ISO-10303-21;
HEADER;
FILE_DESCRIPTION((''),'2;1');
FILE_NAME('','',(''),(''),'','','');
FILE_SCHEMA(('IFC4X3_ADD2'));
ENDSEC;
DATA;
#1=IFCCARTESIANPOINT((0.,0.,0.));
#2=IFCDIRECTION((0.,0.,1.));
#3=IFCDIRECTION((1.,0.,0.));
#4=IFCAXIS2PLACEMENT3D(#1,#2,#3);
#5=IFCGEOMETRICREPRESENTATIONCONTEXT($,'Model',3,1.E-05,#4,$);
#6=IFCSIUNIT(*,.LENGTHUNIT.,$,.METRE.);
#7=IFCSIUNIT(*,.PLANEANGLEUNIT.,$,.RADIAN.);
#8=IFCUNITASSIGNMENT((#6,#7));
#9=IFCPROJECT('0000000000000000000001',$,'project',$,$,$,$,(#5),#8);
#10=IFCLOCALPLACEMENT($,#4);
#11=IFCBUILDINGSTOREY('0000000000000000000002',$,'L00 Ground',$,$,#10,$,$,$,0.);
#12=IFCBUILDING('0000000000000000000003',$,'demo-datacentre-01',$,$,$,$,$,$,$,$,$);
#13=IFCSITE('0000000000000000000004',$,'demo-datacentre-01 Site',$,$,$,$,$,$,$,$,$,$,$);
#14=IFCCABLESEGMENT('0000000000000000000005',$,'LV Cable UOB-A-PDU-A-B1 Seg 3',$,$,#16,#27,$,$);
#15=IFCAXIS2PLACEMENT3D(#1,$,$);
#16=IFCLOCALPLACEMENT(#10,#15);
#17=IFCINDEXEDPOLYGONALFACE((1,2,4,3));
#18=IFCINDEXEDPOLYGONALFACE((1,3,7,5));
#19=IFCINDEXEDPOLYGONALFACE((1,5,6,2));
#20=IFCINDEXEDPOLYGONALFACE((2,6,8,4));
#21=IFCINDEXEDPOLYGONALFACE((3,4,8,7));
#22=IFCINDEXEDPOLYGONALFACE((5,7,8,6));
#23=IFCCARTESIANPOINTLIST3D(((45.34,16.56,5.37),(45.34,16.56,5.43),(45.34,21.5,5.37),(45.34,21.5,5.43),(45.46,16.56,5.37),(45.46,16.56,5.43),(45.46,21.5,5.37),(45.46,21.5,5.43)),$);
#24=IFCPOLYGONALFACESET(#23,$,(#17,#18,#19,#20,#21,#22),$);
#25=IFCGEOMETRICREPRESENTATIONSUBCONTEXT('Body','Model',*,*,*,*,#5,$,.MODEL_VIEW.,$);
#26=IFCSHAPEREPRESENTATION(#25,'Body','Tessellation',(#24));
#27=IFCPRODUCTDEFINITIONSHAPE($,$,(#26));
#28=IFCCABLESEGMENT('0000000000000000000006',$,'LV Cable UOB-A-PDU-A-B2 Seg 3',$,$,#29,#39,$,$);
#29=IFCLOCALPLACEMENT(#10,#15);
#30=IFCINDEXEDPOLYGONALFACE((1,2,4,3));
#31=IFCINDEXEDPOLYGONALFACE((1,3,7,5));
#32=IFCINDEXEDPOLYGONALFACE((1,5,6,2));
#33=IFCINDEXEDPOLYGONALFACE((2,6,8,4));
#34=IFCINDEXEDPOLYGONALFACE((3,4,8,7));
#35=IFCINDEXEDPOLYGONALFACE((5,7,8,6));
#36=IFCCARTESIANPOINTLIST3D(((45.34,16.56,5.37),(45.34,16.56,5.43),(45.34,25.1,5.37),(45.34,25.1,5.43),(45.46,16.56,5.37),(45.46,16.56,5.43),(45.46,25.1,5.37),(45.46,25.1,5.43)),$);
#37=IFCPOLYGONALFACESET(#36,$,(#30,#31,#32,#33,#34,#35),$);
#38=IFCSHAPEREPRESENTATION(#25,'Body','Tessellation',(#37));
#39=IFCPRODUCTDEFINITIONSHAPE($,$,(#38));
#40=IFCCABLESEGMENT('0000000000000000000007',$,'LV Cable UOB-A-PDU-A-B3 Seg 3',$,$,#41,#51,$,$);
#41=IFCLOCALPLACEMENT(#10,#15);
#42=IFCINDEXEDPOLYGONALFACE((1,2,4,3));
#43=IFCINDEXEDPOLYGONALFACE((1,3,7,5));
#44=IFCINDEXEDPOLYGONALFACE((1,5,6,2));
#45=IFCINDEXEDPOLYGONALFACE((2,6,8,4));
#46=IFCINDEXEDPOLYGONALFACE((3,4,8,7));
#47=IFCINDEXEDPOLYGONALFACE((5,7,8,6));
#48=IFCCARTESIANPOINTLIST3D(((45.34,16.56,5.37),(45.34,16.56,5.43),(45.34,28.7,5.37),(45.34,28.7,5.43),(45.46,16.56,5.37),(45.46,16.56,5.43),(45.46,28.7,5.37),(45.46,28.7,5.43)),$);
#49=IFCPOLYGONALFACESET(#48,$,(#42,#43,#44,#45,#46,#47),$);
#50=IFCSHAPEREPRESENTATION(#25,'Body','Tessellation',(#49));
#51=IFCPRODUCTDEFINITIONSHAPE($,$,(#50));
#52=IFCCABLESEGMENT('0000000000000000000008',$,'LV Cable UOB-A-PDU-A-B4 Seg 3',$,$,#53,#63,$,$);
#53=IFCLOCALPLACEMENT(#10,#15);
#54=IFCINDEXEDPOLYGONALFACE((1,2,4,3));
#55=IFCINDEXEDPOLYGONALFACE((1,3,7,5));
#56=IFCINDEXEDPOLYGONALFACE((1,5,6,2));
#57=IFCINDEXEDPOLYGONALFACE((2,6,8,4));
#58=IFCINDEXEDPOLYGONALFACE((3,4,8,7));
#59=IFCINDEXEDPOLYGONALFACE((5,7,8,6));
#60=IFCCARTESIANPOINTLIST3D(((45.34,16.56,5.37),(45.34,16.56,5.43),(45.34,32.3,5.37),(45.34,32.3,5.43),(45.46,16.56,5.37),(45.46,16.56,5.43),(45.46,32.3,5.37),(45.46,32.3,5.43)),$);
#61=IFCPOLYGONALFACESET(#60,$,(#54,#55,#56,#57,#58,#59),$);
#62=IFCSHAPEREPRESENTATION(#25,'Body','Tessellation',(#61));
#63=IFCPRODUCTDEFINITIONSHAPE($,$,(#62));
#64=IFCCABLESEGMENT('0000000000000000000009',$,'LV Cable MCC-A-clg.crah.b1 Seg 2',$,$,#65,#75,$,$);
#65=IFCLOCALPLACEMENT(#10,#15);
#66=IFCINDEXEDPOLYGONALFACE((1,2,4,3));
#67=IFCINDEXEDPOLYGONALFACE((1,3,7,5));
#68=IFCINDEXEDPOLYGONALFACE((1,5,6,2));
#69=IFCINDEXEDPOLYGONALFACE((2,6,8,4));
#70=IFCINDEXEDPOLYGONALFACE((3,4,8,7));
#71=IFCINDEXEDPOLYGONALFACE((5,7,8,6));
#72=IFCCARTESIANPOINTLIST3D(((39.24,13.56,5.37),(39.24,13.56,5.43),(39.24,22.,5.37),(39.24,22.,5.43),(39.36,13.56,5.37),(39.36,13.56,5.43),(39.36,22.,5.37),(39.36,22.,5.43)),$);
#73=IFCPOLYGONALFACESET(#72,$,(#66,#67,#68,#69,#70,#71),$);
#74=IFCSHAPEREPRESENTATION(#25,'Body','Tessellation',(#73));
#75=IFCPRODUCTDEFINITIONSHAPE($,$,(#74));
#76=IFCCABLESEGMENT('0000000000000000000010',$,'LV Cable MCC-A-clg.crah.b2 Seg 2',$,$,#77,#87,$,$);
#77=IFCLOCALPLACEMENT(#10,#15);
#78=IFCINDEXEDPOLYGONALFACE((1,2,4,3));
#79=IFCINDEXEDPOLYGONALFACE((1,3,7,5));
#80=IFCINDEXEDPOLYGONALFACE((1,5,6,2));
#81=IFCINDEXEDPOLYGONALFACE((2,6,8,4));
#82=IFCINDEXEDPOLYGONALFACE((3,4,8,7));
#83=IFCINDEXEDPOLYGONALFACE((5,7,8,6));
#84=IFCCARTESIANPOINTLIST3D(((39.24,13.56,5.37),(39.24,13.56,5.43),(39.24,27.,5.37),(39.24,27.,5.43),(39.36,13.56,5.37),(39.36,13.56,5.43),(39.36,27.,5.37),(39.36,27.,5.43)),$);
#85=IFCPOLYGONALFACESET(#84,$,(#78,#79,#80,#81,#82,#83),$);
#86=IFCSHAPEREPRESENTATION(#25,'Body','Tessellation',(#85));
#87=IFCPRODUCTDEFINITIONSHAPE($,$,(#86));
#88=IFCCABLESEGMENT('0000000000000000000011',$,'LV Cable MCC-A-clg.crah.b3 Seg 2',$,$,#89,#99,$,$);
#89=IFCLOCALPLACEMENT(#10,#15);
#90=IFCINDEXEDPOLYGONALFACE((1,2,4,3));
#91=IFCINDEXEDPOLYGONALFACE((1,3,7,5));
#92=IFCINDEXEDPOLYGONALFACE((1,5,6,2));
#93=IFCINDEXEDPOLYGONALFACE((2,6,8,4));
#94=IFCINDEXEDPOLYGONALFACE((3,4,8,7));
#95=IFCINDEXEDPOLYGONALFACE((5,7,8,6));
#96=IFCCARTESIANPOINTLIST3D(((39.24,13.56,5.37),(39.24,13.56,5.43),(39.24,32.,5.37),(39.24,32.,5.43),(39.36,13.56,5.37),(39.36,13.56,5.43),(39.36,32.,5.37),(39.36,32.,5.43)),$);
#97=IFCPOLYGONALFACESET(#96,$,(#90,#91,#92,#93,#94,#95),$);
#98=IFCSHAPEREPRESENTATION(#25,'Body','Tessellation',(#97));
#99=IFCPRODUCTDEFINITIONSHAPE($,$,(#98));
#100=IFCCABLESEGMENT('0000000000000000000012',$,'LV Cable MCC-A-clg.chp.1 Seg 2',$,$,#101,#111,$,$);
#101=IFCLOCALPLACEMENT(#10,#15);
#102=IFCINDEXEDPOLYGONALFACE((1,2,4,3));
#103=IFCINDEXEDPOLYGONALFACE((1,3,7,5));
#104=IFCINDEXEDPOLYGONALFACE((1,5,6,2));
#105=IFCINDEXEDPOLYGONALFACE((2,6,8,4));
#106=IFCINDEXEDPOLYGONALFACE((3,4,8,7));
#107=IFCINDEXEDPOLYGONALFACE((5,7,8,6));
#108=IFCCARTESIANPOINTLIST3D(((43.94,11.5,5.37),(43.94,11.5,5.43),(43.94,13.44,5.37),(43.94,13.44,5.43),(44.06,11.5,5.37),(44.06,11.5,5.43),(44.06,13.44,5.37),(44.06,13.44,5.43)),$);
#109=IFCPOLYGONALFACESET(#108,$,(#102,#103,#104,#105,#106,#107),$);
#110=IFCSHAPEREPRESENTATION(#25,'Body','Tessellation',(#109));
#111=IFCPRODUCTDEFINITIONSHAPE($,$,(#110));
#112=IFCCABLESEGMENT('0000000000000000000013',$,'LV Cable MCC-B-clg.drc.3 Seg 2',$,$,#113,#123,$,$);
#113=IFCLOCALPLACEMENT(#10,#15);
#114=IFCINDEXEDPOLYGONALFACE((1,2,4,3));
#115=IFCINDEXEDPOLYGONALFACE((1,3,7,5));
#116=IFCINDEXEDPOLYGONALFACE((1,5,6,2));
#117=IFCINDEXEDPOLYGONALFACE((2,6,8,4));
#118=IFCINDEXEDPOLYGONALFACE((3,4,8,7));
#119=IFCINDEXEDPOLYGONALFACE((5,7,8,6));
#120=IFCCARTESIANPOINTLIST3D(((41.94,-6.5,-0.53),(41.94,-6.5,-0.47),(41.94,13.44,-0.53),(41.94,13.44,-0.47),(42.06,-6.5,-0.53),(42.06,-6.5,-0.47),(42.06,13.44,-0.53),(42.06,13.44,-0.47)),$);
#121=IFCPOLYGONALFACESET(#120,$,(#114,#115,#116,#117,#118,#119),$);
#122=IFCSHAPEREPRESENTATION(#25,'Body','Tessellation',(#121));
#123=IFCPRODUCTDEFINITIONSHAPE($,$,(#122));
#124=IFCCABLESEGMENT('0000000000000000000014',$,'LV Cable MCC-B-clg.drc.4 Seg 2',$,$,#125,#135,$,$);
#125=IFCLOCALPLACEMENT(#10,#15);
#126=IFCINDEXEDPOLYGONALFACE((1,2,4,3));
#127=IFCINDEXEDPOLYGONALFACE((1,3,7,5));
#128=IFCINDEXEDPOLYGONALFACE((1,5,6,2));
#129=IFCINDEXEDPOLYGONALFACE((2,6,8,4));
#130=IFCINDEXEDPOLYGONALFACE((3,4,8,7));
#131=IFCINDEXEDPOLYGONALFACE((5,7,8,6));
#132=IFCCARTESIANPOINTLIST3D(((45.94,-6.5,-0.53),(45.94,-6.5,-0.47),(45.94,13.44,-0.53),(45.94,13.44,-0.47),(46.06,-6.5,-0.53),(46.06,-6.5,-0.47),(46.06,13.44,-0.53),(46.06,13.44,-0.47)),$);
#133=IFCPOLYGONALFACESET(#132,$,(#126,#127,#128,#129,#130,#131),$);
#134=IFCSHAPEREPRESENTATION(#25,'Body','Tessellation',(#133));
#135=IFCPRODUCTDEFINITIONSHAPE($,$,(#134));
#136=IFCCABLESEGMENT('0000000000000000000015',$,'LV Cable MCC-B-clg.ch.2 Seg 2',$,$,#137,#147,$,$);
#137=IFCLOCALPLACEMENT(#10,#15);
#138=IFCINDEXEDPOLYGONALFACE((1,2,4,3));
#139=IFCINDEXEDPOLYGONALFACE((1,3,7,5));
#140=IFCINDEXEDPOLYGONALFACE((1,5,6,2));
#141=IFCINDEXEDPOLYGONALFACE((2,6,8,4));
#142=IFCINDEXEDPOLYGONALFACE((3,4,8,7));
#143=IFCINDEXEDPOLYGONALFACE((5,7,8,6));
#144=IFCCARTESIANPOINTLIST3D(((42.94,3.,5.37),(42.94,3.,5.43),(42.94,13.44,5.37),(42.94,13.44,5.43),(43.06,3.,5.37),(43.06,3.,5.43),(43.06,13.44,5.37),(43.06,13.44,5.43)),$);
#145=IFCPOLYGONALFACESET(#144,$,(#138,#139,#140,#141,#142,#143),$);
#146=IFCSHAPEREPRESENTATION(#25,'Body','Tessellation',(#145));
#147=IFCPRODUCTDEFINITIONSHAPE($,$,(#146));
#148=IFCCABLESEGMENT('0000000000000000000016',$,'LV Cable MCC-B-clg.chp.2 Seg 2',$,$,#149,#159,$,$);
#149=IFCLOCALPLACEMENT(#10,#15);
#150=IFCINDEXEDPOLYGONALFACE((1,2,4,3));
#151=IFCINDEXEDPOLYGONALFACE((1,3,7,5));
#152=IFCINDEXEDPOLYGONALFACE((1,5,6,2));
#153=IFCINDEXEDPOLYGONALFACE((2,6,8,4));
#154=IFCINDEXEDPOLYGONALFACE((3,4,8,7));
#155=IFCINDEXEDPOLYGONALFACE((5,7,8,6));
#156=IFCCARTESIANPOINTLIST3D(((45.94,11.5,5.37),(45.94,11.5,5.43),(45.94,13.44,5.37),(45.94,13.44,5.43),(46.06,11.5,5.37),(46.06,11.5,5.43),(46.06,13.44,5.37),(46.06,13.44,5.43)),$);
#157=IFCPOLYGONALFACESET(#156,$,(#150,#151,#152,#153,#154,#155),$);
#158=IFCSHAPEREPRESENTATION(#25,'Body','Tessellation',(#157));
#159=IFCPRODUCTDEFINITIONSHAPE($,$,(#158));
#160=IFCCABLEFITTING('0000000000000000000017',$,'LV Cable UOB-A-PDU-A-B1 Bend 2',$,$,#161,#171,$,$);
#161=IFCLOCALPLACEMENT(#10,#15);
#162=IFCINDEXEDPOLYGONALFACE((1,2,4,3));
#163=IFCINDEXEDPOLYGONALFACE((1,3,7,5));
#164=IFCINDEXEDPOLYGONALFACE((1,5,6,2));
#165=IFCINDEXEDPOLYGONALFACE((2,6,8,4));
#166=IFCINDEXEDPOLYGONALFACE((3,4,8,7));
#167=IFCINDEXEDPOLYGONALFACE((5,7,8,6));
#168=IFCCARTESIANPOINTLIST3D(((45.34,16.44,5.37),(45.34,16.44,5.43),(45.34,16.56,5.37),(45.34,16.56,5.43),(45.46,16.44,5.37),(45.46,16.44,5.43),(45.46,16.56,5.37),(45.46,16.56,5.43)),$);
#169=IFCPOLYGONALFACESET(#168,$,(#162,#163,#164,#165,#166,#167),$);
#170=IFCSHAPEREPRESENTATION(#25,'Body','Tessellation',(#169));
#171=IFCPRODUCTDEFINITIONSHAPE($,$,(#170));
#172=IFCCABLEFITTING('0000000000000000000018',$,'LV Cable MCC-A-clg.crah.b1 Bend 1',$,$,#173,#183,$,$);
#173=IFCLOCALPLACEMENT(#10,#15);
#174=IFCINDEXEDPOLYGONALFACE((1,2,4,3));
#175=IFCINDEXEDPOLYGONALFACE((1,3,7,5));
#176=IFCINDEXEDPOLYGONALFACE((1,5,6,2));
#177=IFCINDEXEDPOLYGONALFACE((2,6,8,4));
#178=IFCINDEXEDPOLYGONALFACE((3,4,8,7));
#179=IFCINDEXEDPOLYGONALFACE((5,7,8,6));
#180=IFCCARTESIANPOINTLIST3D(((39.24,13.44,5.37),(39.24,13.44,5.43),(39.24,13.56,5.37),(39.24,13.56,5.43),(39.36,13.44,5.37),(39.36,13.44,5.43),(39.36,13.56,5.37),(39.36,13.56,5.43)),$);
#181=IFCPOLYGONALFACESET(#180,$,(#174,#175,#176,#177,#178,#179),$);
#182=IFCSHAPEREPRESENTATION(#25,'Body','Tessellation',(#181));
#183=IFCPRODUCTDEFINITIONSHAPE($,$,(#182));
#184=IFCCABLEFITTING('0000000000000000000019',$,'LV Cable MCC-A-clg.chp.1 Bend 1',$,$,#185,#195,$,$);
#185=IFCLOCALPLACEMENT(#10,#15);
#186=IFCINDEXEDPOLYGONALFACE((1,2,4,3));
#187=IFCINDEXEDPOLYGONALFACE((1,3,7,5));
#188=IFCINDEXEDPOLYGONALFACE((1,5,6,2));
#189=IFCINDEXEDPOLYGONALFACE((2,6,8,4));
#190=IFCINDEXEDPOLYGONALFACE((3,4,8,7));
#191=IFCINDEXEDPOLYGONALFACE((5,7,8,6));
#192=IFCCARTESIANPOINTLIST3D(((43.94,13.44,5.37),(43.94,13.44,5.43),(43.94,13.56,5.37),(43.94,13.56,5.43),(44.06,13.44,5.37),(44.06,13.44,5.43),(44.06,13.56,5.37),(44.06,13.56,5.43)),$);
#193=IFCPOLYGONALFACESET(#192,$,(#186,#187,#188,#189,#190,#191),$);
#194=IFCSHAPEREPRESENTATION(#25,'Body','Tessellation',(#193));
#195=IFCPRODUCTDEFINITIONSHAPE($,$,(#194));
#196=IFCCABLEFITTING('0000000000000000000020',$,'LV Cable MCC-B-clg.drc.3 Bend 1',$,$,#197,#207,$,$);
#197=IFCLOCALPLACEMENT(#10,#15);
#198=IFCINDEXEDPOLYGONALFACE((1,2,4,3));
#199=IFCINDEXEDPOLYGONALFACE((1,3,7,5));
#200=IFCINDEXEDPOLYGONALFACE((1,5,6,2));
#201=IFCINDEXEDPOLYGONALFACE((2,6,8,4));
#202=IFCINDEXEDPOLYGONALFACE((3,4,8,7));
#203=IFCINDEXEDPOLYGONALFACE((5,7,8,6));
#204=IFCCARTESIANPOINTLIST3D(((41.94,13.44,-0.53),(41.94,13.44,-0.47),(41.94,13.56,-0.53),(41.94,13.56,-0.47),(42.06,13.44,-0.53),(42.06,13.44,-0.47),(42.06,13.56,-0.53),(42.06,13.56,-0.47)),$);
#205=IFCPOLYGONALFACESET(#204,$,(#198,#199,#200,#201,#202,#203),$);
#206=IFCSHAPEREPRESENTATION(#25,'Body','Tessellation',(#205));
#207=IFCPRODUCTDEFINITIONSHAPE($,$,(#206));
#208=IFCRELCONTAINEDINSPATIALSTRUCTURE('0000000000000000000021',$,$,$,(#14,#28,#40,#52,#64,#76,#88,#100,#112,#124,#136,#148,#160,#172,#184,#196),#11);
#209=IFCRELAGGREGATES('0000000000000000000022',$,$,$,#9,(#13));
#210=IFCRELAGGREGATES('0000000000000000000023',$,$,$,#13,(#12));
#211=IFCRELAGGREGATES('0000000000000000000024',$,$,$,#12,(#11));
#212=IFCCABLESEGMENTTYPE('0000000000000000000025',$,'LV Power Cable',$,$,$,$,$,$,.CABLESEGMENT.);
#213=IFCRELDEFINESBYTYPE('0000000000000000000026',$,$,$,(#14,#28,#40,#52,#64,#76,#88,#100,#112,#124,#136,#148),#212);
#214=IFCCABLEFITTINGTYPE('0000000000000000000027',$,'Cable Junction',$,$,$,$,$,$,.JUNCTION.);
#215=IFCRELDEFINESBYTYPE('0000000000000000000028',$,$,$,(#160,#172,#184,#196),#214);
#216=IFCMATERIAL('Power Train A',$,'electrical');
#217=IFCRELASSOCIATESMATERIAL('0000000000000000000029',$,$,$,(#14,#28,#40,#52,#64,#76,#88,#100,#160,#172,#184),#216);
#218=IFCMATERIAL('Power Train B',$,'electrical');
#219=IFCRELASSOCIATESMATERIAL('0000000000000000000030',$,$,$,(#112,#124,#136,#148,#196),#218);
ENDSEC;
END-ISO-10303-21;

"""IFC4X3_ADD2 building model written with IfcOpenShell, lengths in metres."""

from ifc_helpers import new_model, si_unit, frame, origin_with_axes, place, context, subcontext, project, spatial, rectangle, extrude, material, type_object, element, save


model = new_model("IFC4X3_ADD2")

# Units and contexts
model_context = context("Model", 3, precision=1e-05, world=origin_with_axes())
body_context = subcontext(model_context, "Body", "Model", "MODEL_VIEW")
ifc_project = project(units=[si_unit("LENGTHUNIT", "METRE"), si_unit("PLANEANGLEUNIT", "RADIAN")], contexts=[model_context])

# Site, building, storey
site = spatial("IfcSite", under=ifc_project, Name="demo-datacentre-01 Site")
building = spatial("IfcBuilding", under=site, Name="demo-datacentre-01")
storey_placement = place(None, origin_with_axes())
storey = spatial("IfcBuildingStorey", under=building, at=storey_placement, Name="L00 Ground", Elevation=0.0)

# Cable segments
ifc_material_1 = material(Name="Power Train A", Category="electrical")
cable_segment_type_1 = type_object("IfcCableSegmentType", Name="LV Power Cable", PredefinedType="CABLESEGMENT")
cable_segment_1_placement = place(storey_placement, frame((45.4, 16.56, 5.4), z_axis=(0.0, 1.0, 0.0), x_axis=(-1.0, 0.0, 0.0)))
element("IfcCableSegment", 1, at=cable_segment_1_placement, inside=storey, type_object=cable_segment_type_1, material=ifc_material_1, Name="LV Cable UOB-A-PDU-A-B1 Seg 3", context=body_context, shape_type="SweptSolid", body=[
    extrude(rectangle(XDim=0.12, YDim=0.06), origin_with_axes(), (0.0, 0.0, 1.0), 4.94),
])
cable_segment_2_placement = place(storey_placement, frame((45.4, 16.56, 5.4), z_axis=(0.0, 1.0, 0.0), x_axis=(-1.0, 0.0, 0.0)))
element("IfcCableSegment", 2, at=cable_segment_2_placement, inside=storey, type_object=cable_segment_type_1, material=ifc_material_1, Name="LV Cable UOB-A-PDU-A-B2 Seg 3", context=body_context, shape_type="SweptSolid", body=[
    extrude(rectangle(XDim=0.12, YDim=0.06), origin_with_axes(), (0.0, 0.0, 1.0), 8.54),
])
cable_segment_3_placement = place(storey_placement, frame((45.4, 16.56, 5.4), z_axis=(0.0, 1.0, 0.0), x_axis=(-1.0, 0.0, 0.0)))
element("IfcCableSegment", 3, at=cable_segment_3_placement, inside=storey, type_object=cable_segment_type_1, material=ifc_material_1, Name="LV Cable UOB-A-PDU-A-B3 Seg 3", context=body_context, shape_type="SweptSolid", body=[
    extrude(rectangle(XDim=0.12, YDim=0.06), origin_with_axes(), (0.0, 0.0, 1.0), 12.14),
])
cable_segment_4_placement = place(storey_placement, frame((45.4, 16.56, 5.4), z_axis=(0.0, 1.0, 0.0), x_axis=(-1.0, 0.0, 0.0)))
element("IfcCableSegment", 4, at=cable_segment_4_placement, inside=storey, type_object=cable_segment_type_1, material=ifc_material_1, Name="LV Cable UOB-A-PDU-A-B4 Seg 3", context=body_context, shape_type="SweptSolid", body=[
    extrude(rectangle(XDim=0.12, YDim=0.06), origin_with_axes(), (0.0, 0.0, 1.0), 15.74),
])
cable_segment_5_placement = place(storey_placement, frame((39.3, 13.56, 5.4), z_axis=(0.0, 1.0, 0.0), x_axis=(-1.0, 0.0, 0.0)))
element("IfcCableSegment", 5, at=cable_segment_5_placement, inside=storey, type_object=cable_segment_type_1, material=ifc_material_1, Name="LV Cable MCC-A-clg.crah.b1 Seg 2", context=body_context, shape_type="SweptSolid", body=[
    extrude(rectangle(XDim=0.12, YDim=0.06), origin_with_axes(), (0.0, 0.0, 1.0), 8.44),
])
cable_segment_6_placement = place(storey_placement, frame((39.3, 13.56, 5.4), z_axis=(0.0, 1.0, 0.0), x_axis=(-1.0, 0.0, 0.0)))
element("IfcCableSegment", 6, at=cable_segment_6_placement, inside=storey, type_object=cable_segment_type_1, material=ifc_material_1, Name="LV Cable MCC-A-clg.crah.b2 Seg 2", context=body_context, shape_type="SweptSolid", body=[
    extrude(rectangle(XDim=0.12, YDim=0.06), origin_with_axes(), (0.0, 0.0, 1.0), 13.44),
])
cable_segment_7_placement = place(storey_placement, frame((39.3, 13.56, 5.4), z_axis=(0.0, 1.0, 0.0), x_axis=(-1.0, 0.0, 0.0)))
element("IfcCableSegment", 7, at=cable_segment_7_placement, inside=storey, type_object=cable_segment_type_1, material=ifc_material_1, Name="LV Cable MCC-A-clg.crah.b3 Seg 2", context=body_context, shape_type="SweptSolid", body=[
    extrude(rectangle(XDim=0.12, YDim=0.06), origin_with_axes(), (0.0, 0.0, 1.0), 18.44),
])
cable_segment_8_placement = place(storey_placement, frame((44.0, 13.44, 5.4), z_axis=(0.0, -1.0, 0.0), x_axis=(1.0, 0.0, 0.0)))
element("IfcCableSegment", 8, at=cable_segment_8_placement, inside=storey, type_object=cable_segment_type_1, material=ifc_material_1, Name="LV Cable MCC-A-clg.chp.1 Seg 2", context=body_context, shape_type="SweptSolid", body=[
    extrude(rectangle(XDim=0.12, YDim=0.06), origin_with_axes(), (0.0, 0.0, 1.0), 1.94),
])
ifc_material_2 = material(Name="Power Train B", Category="electrical")
for number, where, z_axis, x_axis, name in (
    (9, (42.0, 13.44, -0.5), (0.0, -1.0, 0.0), (1.0, 0.0, 0.0), "LV Cable MCC-B-clg.drc.3 Seg 2"),
    (10, (46.0, 13.44, -0.5), (0.0, -1.0, 0.0), (1.0, 0.0, 0.0), "LV Cable MCC-B-clg.drc.4 Seg 2"),
):
    element("IfcCableSegment", number, at=place(storey_placement, frame(where, z_axis=z_axis, x_axis=x_axis)), inside=storey, type_object=cable_segment_type_1, material=ifc_material_2, Name=name, context=body_context, shape_type="SweptSolid", body=[
        extrude(rectangle(XDim=0.12, YDim=0.06), origin_with_axes(), (0.0, 0.0, 1.0), 19.94),
    ])
cable_segment_9_placement = place(storey_placement, frame((43.0, 13.44, 5.4), z_axis=(0.0, -1.0, 0.0), x_axis=(1.0, 0.0, 0.0)))
element("IfcCableSegment", 11, at=cable_segment_9_placement, inside=storey, type_object=cable_segment_type_1, material=ifc_material_2, Name="LV Cable MCC-B-clg.ch.2 Seg 2", context=body_context, shape_type="SweptSolid", body=[
    extrude(rectangle(XDim=0.12, YDim=0.06), origin_with_axes(), (0.0, 0.0, 1.0), 10.44),
])
cable_segment_10_placement = place(storey_placement, frame((46.0, 13.44, 5.4), z_axis=(0.0, -1.0, 0.0), x_axis=(1.0, 0.0, 0.0)))
element("IfcCableSegment", 12, at=cable_segment_10_placement, inside=storey, type_object=cable_segment_type_1, material=ifc_material_2, Name="LV Cable MCC-B-clg.chp.2 Seg 2", context=body_context, shape_type="SweptSolid", body=[
    extrude(rectangle(XDim=0.12, YDim=0.06), origin_with_axes(), (0.0, 0.0, 1.0), 1.94),
])

# Cable fittings
cable_fitting_type_1 = type_object("IfcCableFittingType", Name="Cable Junction", PredefinedType="JUNCTION")
for number, where, z_axis, x_axis, name in (
    (13, (45.4, 16.5, 5.37), (0.0, 0.0, 1.0), (1.0, 0.0, 0.0), "LV Cable UOB-A-PDU-A-B1 Bend 2"),
    (14, (39.3, 13.5, 5.37), (0.0, 0.0, 1.0), (1.0, 0.0, 0.0), "LV Cable MCC-A-clg.crah.b1 Bend 1"),
    (15, (44.0, 13.5, 5.37), (0.0, 0.0, 1.0), (1.0, 0.0, 0.0), "LV Cable MCC-A-clg.chp.1 Bend 1"),
):
    element("IfcCableFitting", number, at=place(storey_placement, frame(where, z_axis=z_axis, x_axis=x_axis)), inside=storey, type_object=cable_fitting_type_1, material=ifc_material_1, Name=name, context=body_context, shape_type="SweptSolid", body=[
        extrude(rectangle(XDim=0.12, YDim=0.12), origin_with_axes(), (0.0, 0.0, 1.0), 0.06),
    ])
for number, where, z_axis, x_axis, name in (
    (16, (42.0, 13.5, -0.53), (0.0, 0.0, 1.0), (1.0, 0.0, 0.0), "LV Cable MCC-B-clg.drc.3 Bend 1"),
):
    element("IfcCableFitting", number, at=place(storey_placement, frame(where, z_axis=z_axis, x_axis=x_axis)), inside=storey, type_object=cable_fitting_type_1, material=ifc_material_2, Name=name, context=body_context, shape_type="SweptSolid", body=[
        extrude(rectangle(XDim=0.12, YDim=0.12), origin_with_axes(), (0.0, 0.0, 1.0), 0.06),
    ])

save(model, "model.ifc")
